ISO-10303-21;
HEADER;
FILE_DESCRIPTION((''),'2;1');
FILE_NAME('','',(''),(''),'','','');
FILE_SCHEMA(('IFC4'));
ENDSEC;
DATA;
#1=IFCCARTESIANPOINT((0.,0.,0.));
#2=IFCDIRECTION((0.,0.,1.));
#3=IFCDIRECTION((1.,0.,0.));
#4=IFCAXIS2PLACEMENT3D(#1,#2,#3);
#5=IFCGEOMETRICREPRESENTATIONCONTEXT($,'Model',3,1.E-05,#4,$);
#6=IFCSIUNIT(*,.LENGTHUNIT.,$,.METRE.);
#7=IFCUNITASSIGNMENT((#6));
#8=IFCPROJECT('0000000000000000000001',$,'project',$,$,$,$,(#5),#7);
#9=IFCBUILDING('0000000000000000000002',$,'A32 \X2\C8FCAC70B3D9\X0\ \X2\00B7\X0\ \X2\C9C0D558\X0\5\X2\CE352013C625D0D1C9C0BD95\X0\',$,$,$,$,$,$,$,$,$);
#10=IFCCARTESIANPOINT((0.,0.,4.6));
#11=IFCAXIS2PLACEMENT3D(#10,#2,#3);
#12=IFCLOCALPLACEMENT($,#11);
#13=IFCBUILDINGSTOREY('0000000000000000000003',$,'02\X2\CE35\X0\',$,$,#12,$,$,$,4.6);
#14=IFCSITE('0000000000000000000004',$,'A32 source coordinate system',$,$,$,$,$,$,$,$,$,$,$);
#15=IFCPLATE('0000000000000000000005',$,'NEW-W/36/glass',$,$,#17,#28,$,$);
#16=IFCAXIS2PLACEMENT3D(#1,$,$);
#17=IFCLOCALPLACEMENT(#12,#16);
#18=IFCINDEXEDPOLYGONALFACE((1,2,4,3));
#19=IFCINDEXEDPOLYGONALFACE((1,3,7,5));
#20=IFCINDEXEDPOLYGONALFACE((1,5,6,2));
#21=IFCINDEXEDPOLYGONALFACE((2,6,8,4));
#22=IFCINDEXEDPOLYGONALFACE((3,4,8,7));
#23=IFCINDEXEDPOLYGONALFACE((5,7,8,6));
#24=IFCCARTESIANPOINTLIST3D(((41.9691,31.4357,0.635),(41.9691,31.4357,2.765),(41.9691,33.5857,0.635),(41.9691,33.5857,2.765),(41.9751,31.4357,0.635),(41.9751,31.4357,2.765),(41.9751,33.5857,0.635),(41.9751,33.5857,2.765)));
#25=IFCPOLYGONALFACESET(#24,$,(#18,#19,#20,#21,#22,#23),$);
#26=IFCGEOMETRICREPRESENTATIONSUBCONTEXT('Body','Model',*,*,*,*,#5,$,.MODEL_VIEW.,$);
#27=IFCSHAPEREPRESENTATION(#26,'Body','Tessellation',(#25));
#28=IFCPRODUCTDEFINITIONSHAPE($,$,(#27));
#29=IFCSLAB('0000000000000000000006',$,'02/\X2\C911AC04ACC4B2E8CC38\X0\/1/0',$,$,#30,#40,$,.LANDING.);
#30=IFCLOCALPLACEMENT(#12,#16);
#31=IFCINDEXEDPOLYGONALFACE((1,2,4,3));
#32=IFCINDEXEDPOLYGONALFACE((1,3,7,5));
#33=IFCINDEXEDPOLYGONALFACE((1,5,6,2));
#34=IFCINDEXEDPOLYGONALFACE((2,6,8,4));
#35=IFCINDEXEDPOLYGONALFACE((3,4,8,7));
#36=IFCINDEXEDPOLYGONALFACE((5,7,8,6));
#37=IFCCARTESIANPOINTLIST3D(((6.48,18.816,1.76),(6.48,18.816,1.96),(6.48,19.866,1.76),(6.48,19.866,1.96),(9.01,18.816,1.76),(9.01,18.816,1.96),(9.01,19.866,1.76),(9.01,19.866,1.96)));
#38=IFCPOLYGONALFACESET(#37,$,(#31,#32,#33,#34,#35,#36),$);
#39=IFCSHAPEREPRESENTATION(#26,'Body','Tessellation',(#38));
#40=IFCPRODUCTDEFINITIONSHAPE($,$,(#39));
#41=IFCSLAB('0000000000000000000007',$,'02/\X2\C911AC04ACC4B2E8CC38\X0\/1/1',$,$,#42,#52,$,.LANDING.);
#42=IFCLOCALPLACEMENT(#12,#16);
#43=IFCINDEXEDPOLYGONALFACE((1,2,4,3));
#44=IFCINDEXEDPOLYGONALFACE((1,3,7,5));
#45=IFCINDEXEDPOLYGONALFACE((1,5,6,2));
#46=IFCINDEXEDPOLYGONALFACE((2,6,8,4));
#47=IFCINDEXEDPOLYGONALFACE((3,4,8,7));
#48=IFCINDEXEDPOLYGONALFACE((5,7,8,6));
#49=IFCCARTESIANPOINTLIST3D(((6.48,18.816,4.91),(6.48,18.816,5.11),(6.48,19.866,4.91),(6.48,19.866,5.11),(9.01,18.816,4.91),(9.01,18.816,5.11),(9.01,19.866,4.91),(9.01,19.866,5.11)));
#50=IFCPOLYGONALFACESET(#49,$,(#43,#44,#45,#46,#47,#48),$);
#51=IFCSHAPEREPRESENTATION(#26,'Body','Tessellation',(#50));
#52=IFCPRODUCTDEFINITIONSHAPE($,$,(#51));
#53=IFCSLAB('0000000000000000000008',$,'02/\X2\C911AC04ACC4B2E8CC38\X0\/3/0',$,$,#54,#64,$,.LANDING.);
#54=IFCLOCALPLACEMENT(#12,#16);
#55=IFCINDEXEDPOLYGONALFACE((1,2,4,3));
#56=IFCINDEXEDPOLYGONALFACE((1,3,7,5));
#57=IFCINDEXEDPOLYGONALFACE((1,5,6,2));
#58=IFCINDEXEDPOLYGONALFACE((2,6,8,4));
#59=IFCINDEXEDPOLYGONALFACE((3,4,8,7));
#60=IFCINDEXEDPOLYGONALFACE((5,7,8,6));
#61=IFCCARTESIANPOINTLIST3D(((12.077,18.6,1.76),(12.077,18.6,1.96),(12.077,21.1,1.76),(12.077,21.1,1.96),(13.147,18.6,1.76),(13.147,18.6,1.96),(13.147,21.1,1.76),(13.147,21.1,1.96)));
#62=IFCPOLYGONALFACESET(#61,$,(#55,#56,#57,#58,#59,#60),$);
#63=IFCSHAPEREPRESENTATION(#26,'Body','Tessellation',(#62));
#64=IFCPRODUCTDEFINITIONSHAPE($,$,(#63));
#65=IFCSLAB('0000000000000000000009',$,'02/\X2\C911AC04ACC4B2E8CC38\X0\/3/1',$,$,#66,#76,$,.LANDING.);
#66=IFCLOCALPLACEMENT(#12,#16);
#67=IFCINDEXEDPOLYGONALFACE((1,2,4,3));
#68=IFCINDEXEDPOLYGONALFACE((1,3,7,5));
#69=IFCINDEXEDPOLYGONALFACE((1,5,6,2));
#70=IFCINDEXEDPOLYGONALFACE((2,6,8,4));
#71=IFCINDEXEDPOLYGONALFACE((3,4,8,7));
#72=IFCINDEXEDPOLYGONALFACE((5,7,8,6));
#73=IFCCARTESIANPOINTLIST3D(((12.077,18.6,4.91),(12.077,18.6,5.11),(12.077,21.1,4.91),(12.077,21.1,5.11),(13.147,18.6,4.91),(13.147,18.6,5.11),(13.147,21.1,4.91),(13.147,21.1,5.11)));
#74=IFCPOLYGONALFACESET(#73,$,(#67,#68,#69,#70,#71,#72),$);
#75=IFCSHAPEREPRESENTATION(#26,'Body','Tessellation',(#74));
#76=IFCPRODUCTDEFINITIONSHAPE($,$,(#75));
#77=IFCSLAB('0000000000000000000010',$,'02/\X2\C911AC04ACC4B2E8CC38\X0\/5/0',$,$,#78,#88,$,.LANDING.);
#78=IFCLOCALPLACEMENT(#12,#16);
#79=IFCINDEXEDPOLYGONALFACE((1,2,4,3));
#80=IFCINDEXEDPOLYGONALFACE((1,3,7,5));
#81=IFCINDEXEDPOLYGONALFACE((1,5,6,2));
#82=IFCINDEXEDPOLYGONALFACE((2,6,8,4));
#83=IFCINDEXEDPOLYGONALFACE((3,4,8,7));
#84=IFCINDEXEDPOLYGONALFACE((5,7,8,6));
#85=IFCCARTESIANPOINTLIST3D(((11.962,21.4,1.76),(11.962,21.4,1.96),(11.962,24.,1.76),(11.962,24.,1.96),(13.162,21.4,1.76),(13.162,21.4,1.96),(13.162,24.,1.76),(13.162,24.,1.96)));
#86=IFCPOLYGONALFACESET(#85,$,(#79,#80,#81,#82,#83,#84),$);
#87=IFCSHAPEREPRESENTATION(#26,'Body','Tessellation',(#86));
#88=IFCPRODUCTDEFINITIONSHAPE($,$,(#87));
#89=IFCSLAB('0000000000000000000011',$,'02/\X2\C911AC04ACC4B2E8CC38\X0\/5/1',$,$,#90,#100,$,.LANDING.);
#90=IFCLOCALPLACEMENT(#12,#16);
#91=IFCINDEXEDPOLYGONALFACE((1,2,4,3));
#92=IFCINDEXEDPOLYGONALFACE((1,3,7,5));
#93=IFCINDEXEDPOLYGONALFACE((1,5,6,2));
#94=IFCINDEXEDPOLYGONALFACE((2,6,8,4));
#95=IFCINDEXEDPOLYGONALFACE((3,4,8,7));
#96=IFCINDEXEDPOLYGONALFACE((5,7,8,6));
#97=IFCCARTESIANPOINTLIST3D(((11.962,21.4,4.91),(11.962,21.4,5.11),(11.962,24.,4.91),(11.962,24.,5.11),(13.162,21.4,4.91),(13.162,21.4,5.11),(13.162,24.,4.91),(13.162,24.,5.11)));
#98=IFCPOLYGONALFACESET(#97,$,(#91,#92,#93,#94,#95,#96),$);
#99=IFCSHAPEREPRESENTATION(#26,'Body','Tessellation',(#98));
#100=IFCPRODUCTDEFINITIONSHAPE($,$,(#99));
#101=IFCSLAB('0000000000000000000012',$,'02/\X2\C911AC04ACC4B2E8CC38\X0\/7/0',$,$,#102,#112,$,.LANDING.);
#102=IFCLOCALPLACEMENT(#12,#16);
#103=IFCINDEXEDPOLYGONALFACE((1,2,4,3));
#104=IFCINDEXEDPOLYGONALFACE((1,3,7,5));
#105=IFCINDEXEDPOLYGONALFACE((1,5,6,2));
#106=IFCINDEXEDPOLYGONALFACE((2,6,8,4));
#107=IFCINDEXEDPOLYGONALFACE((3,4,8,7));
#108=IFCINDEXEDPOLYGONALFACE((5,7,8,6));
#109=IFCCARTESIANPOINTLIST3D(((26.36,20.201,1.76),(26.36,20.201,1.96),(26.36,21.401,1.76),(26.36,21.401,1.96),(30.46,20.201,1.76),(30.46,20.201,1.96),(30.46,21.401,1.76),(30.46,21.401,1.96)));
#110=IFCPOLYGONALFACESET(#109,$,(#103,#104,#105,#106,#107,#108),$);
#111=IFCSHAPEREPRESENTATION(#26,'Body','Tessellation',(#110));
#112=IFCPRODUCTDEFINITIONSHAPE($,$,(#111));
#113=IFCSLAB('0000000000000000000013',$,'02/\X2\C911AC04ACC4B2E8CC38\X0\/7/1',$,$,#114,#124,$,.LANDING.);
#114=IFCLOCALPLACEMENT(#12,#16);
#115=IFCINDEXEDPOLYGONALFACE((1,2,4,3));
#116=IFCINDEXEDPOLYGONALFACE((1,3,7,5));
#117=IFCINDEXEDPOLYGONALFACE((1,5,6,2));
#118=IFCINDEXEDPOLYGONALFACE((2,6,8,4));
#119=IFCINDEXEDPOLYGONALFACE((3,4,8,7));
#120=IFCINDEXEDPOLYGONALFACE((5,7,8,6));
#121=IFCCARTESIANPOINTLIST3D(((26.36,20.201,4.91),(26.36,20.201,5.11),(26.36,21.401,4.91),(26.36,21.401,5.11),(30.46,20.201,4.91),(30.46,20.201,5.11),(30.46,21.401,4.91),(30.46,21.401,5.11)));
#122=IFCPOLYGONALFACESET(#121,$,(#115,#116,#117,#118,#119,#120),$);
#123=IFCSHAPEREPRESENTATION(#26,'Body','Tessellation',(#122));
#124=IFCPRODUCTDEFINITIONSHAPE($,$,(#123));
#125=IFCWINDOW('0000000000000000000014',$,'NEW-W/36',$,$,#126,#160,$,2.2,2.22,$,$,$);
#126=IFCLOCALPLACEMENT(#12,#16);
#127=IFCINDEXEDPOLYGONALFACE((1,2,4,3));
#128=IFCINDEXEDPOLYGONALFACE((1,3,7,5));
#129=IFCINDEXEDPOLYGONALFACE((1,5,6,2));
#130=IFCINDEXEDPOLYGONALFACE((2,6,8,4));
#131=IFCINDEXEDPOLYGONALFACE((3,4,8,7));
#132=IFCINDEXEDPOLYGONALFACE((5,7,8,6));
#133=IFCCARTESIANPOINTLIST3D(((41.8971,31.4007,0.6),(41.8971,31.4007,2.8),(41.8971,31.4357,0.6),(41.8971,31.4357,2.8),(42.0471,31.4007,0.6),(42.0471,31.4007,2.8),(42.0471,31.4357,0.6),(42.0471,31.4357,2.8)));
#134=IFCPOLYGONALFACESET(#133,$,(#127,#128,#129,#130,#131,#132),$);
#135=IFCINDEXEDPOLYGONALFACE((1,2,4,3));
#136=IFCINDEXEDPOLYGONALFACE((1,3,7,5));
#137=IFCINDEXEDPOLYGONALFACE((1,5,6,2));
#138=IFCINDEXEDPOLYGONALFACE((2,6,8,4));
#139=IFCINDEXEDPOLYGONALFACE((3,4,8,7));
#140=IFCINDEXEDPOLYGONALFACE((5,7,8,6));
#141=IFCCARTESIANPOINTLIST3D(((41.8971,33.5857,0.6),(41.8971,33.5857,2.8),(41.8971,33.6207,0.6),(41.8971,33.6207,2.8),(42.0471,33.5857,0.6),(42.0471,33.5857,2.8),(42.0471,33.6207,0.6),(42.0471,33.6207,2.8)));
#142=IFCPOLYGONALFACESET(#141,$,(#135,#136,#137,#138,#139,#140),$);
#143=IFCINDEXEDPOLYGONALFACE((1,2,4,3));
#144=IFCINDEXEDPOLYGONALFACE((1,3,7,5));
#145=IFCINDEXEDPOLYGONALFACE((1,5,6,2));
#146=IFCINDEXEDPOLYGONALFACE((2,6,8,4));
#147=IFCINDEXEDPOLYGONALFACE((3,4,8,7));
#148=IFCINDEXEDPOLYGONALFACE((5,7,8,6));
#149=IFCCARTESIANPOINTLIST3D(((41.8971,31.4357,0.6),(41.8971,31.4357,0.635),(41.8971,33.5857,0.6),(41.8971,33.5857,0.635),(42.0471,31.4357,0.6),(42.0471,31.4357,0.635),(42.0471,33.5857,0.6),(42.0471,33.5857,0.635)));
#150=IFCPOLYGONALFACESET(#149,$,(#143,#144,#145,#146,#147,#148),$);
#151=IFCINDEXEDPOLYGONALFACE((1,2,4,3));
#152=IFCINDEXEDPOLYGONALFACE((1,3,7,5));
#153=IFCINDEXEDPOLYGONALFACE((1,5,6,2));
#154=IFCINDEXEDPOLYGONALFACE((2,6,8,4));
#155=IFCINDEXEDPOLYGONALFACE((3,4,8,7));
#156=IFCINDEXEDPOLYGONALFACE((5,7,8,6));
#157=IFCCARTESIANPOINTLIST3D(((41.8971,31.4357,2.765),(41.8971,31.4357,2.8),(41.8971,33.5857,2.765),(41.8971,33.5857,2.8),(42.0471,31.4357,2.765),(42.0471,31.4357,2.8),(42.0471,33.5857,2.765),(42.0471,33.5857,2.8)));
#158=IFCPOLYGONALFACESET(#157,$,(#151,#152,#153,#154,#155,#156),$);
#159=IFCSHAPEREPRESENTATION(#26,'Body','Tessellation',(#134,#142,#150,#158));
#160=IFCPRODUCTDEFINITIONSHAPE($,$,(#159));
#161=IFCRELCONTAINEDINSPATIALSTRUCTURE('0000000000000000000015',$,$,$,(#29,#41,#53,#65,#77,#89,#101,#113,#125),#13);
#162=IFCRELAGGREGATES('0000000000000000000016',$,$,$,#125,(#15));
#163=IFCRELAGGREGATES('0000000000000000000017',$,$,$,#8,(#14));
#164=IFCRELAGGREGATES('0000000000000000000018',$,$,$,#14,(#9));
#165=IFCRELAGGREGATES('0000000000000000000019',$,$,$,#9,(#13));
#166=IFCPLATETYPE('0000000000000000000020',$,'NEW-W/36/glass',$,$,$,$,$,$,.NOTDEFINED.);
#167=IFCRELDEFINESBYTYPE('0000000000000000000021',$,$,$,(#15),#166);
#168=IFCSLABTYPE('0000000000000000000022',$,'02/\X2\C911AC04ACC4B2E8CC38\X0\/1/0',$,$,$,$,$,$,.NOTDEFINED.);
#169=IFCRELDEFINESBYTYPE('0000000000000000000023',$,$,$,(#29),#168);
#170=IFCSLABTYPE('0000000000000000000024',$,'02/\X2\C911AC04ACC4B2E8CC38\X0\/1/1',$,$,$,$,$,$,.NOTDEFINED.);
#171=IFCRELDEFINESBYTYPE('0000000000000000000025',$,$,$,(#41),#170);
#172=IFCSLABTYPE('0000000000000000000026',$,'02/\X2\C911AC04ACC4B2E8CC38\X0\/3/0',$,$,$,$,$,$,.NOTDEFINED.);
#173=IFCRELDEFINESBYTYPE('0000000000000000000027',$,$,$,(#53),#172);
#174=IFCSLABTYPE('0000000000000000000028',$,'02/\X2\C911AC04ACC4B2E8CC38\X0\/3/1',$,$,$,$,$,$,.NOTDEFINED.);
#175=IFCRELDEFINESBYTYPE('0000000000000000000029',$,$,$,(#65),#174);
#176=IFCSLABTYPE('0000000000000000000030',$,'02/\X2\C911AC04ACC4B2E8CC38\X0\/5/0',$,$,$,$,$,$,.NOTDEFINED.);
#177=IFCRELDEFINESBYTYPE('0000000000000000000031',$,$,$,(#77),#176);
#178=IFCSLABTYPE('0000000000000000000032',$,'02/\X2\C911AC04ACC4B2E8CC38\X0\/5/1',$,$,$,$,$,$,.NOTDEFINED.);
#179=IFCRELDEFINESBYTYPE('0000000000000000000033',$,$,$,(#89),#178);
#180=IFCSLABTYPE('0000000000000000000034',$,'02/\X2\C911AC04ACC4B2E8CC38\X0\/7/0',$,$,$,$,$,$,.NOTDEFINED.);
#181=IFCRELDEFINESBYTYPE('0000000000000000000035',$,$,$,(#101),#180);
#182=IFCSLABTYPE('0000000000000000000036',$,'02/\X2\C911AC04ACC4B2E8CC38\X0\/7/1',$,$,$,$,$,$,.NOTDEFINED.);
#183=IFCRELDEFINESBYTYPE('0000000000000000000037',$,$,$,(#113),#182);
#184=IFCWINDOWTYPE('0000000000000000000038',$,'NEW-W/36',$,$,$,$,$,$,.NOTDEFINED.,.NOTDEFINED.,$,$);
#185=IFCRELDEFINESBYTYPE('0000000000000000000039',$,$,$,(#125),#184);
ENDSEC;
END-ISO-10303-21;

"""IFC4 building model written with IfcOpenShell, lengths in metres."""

from ifc_helpers import new_model, si_unit, frame, origin, origin_with_axes, place, context, subcontext, project, spatial, polyline, outline, extrude, source, transform, mapped, type_object, type_shapes, element, aggregate, save


model = new_model("IFC4")

# Units and contexts
model_context = context("Model", 3, precision=1e-05, world=origin_with_axes())
body_context = subcontext(model_context, "Body", "Model", "MODEL_VIEW")
ifc_project = project(units=[si_unit("LENGTHUNIT", "METRE")], contexts=[model_context])

# Plate
plate_type = type_object("IfcPlateType", Name="NEW-W/36/glass", PredefinedType="NOTDEFINED")
shared_shape_1 = source(origin(), body_context, "Body", "SweptSolid", [
    extrude(outline(polyline([(41.9751, 31.4357), (41.9691, 31.4357), (41.9691, 33.5857), (41.9751, 33.5857), (41.9751, 31.4357)])), frame((0.0, 0.0, 0.635)), (0.0, 0.0, 1.0), 2.13),
])
type_shapes(plate_type, [shared_shape_1])
storey_placement = place(None, frame((0.0, 0.0, 4.6), z_axis=(0.0, 0.0, 1.0), x_axis=(1.0, 0.0, 0.0)))
window_placement = place(storey_placement, origin_with_axes())
plate_placement = place(window_placement, origin_with_axes())
plate = element("IfcPlate", 1, at=plate_placement, type_object=plate_type, Name="NEW-W/36/glass", context=body_context, shape_type="MappedRepresentation", body=[
    mapped(shared_shape_1, transform((0.0, 0.0, 0.0), scale=1.0)),
])

# Site, building, storey
site = spatial("IfcSite", under=ifc_project, Name="A32 source coordinate system")
building = spatial("IfcBuilding", under=site, Name="A32 주거동 · 지하5층–옥탑지붕")
storey = spatial("IfcBuildingStorey", under=building, at=storey_placement, Name="02층", Elevation=4.6)

# Slabs
slab_type_1 = type_object("IfcSlabType", Name="02/중간계단참/1/0", PredefinedType="NOTDEFINED")
shared_shape_2 = source(origin(), body_context, "Body", "SweptSolid", [
    extrude(outline(polyline([(9.01, 18.816), (6.48, 18.816), (6.48, 19.866), (9.01, 19.866), (9.01, 18.816)])), frame((0.0, 0.0, 1.76)), (0.0, 0.0, 1.0), 0.2),
])
type_shapes(slab_type_1, [shared_shape_2])
slab_1_placement = place(storey_placement, origin_with_axes())
element("IfcSlab", 2, at=slab_1_placement, inside=storey, type_object=slab_type_1, Name="02/중간계단참/1/0", PredefinedType="LANDING", context=body_context, shape_type="MappedRepresentation", body=[
    mapped(shared_shape_2, transform((0.0, 0.0, 0.0), scale=1.0)),
])
slab_type_2 = type_object("IfcSlabType", Name="02/중간계단참/1/1", PredefinedType="NOTDEFINED")
shared_shape_3 = source(origin(), body_context, "Body", "SweptSolid", [
    extrude(outline(polyline([(9.01, 18.816), (6.48, 18.816), (6.48, 19.866), (9.01, 19.866), (9.01, 18.816)])), frame((0.0, 0.0, 4.91)), (0.0, 0.0, 1.0), 0.2),
])
type_shapes(slab_type_2, [shared_shape_3])
slab_2_placement = place(storey_placement, origin_with_axes())
element("IfcSlab", 3, at=slab_2_placement, inside=storey, type_object=slab_type_2, Name="02/중간계단참/1/1", PredefinedType="LANDING", context=body_context, shape_type="MappedRepresentation", body=[
    mapped(shared_shape_3, transform((0.0, 0.0, 0.0), scale=1.0)),
])
slab_type_3 = type_object("IfcSlabType", Name="02/중간계단참/3/0", PredefinedType="NOTDEFINED")
shared_shape_4 = source(origin(), body_context, "Body", "SweptSolid", [
    extrude(outline(polyline([(13.147, 18.6), (12.077, 18.6), (12.077, 21.1), (13.147, 21.1), (13.147, 18.6)])), frame((0.0, 0.0, 1.76)), (0.0, 0.0, 1.0), 0.2),
])
type_shapes(slab_type_3, [shared_shape_4])
slab_3_placement = place(storey_placement, origin_with_axes())
element("IfcSlab", 4, at=slab_3_placement, inside=storey, type_object=slab_type_3, Name="02/중간계단참/3/0", PredefinedType="LANDING", context=body_context, shape_type="MappedRepresentation", body=[
    mapped(shared_shape_4, transform((0.0, 0.0, 0.0), scale=1.0)),
])
slab_type_4 = type_object("IfcSlabType", Name="02/중간계단참/3/1", PredefinedType="NOTDEFINED")
shared_shape_5 = source(origin(), body_context, "Body", "SweptSolid", [
    extrude(outline(polyline([(13.147, 18.6), (12.077, 18.6), (12.077, 21.1), (13.147, 21.1), (13.147, 18.6)])), frame((0.0, 0.0, 4.91)), (0.0, 0.0, 1.0), 0.2),
])
type_shapes(slab_type_4, [shared_shape_5])
slab_4_placement = place(storey_placement, origin_with_axes())
element("IfcSlab", 5, at=slab_4_placement, inside=storey, type_object=slab_type_4, Name="02/중간계단참/3/1", PredefinedType="LANDING", context=body_context, shape_type="MappedRepresentation", body=[
    mapped(shared_shape_5, transform((0.0, 0.0, 0.0), scale=1.0)),
])
slab_type_5 = type_object("IfcSlabType", Name="02/중간계단참/5/0", PredefinedType="NOTDEFINED")
shared_shape_6 = source(origin(), body_context, "Body", "SweptSolid", [
    extrude(outline(polyline([(13.162, 21.4), (11.962, 21.4), (11.962, 24.0), (13.162, 24.0), (13.162, 21.4)])), frame((0.0, 0.0, 1.76)), (0.0, 0.0, 1.0), 0.2),
])
type_shapes(slab_type_5, [shared_shape_6])
slab_5_placement = place(storey_placement, origin_with_axes())
element("IfcSlab", 6, at=slab_5_placement, inside=storey, type_object=slab_type_5, Name="02/중간계단참/5/0", PredefinedType="LANDING", context=body_context, shape_type="MappedRepresentation", body=[
    mapped(shared_shape_6, transform((0.0, 0.0, 0.0), scale=1.0)),
])
slab_type_6 = type_object("IfcSlabType", Name="02/중간계단참/5/1", PredefinedType="NOTDEFINED")
shared_shape_7 = source(origin(), body_context, "Body", "SweptSolid", [
    extrude(outline(polyline([(13.162, 21.4), (11.962, 21.4), (11.962, 24.0), (13.162, 24.0), (13.162, 21.4)])), frame((0.0, 0.0, 4.91)), (0.0, 0.0, 1.0), 0.2),
])
type_shapes(slab_type_6, [shared_shape_7])
slab_6_placement = place(storey_placement, origin_with_axes())
element("IfcSlab", 7, at=slab_6_placement, inside=storey, type_object=slab_type_6, Name="02/중간계단참/5/1", PredefinedType="LANDING", context=body_context, shape_type="MappedRepresentation", body=[
    mapped(shared_shape_7, transform((0.0, 0.0, 0.0), scale=1.0)),
])
slab_type_7 = type_object("IfcSlabType", Name="02/중간계단참/7/0", PredefinedType="NOTDEFINED")
shared_shape_8 = source(origin(), body_context, "Body", "SweptSolid", [
    extrude(outline(polyline([(30.46, 20.201), (26.36, 20.201), (26.36, 21.401), (30.46, 21.401), (30.46, 20.201)])), frame((0.0, 0.0, 1.76)), (0.0, 0.0, 1.0), 0.2),
])
type_shapes(slab_type_7, [shared_shape_8])
slab_7_placement = place(storey_placement, origin_with_axes())
element("IfcSlab", 8, at=slab_7_placement, inside=storey, type_object=slab_type_7, Name="02/중간계단참/7/0", PredefinedType="LANDING", context=body_context, shape_type="MappedRepresentation", body=[
    mapped(shared_shape_8, transform((0.0, 0.0, 0.0), scale=1.0)),
])
slab_type_8 = type_object("IfcSlabType", Name="02/중간계단참/7/1", PredefinedType="NOTDEFINED")
shared_shape_9 = source(origin(), body_context, "Body", "SweptSolid", [
    extrude(outline(polyline([(30.46, 20.201), (26.36, 20.201), (26.36, 21.401), (30.46, 21.401), (30.46, 20.201)])), frame((0.0, 0.0, 4.91)), (0.0, 0.0, 1.0), 0.2),
])
type_shapes(slab_type_8, [shared_shape_9])
slab_8_placement = place(storey_placement, origin_with_axes())
element("IfcSlab", 9, at=slab_8_placement, inside=storey, type_object=slab_type_8, Name="02/중간계단참/7/1", PredefinedType="LANDING", context=body_context, shape_type="MappedRepresentation", body=[
    mapped(shared_shape_9, transform((0.0, 0.0, 0.0), scale=1.0)),
])

# Window
window_type = type_object("IfcWindowType", Name="NEW-W/36", PartitioningType="NOTDEFINED", PredefinedType="NOTDEFINED")
shared_shape_10 = source(origin(), body_context, "Body", "SweptSolid", [
    extrude(outline(polyline([(41.8971, 31.4007), (41.8971, 31.4357), (42.0471, 31.4357), (42.0471, 31.4007), (41.8971, 31.4007)])), frame((0.0, 0.0, 0.6)), (0.0, 0.0, 1.0), 2.2),
    extrude(outline(polyline([(41.8971, 33.5857), (41.8971, 33.6207), (42.0471, 33.6207), (42.0471, 33.5857), (41.8971, 33.5857)])), frame((0.0, 0.0, 0.6)), (0.0, 0.0, 1.0), 2.2),
    extrude(outline(polyline([(42.0471, 31.4357), (42.0471, 33.5857), (41.8971, 33.5857), (41.8971, 31.4357), (42.0471, 31.4357)])), frame((0.0, 0.0, 0.6)), (0.0, 0.0, 1.0), 0.035),
    extrude(outline(polyline([(42.0471, 31.4357), (42.0471, 33.5857), (41.8971, 33.5857), (41.8971, 31.4357), (42.0471, 31.4357)])), frame((0.0, 0.0, 2.765)), (0.0, 0.0, 1.0), 0.035),
])
type_shapes(window_type, [shared_shape_10])
window = element("IfcWindow", 10, at=window_placement, inside=storey, type_object=window_type, Name="NEW-W/36", OverallHeight=2.2, OverallWidth=2.22, context=body_context, shape_type="MappedRepresentation", body=[
    mapped(shared_shape_10, transform((0.0, 0.0, 0.0), scale=1.0)),
])
aggregate(window, [plate])

save(model, "model.ifc")
